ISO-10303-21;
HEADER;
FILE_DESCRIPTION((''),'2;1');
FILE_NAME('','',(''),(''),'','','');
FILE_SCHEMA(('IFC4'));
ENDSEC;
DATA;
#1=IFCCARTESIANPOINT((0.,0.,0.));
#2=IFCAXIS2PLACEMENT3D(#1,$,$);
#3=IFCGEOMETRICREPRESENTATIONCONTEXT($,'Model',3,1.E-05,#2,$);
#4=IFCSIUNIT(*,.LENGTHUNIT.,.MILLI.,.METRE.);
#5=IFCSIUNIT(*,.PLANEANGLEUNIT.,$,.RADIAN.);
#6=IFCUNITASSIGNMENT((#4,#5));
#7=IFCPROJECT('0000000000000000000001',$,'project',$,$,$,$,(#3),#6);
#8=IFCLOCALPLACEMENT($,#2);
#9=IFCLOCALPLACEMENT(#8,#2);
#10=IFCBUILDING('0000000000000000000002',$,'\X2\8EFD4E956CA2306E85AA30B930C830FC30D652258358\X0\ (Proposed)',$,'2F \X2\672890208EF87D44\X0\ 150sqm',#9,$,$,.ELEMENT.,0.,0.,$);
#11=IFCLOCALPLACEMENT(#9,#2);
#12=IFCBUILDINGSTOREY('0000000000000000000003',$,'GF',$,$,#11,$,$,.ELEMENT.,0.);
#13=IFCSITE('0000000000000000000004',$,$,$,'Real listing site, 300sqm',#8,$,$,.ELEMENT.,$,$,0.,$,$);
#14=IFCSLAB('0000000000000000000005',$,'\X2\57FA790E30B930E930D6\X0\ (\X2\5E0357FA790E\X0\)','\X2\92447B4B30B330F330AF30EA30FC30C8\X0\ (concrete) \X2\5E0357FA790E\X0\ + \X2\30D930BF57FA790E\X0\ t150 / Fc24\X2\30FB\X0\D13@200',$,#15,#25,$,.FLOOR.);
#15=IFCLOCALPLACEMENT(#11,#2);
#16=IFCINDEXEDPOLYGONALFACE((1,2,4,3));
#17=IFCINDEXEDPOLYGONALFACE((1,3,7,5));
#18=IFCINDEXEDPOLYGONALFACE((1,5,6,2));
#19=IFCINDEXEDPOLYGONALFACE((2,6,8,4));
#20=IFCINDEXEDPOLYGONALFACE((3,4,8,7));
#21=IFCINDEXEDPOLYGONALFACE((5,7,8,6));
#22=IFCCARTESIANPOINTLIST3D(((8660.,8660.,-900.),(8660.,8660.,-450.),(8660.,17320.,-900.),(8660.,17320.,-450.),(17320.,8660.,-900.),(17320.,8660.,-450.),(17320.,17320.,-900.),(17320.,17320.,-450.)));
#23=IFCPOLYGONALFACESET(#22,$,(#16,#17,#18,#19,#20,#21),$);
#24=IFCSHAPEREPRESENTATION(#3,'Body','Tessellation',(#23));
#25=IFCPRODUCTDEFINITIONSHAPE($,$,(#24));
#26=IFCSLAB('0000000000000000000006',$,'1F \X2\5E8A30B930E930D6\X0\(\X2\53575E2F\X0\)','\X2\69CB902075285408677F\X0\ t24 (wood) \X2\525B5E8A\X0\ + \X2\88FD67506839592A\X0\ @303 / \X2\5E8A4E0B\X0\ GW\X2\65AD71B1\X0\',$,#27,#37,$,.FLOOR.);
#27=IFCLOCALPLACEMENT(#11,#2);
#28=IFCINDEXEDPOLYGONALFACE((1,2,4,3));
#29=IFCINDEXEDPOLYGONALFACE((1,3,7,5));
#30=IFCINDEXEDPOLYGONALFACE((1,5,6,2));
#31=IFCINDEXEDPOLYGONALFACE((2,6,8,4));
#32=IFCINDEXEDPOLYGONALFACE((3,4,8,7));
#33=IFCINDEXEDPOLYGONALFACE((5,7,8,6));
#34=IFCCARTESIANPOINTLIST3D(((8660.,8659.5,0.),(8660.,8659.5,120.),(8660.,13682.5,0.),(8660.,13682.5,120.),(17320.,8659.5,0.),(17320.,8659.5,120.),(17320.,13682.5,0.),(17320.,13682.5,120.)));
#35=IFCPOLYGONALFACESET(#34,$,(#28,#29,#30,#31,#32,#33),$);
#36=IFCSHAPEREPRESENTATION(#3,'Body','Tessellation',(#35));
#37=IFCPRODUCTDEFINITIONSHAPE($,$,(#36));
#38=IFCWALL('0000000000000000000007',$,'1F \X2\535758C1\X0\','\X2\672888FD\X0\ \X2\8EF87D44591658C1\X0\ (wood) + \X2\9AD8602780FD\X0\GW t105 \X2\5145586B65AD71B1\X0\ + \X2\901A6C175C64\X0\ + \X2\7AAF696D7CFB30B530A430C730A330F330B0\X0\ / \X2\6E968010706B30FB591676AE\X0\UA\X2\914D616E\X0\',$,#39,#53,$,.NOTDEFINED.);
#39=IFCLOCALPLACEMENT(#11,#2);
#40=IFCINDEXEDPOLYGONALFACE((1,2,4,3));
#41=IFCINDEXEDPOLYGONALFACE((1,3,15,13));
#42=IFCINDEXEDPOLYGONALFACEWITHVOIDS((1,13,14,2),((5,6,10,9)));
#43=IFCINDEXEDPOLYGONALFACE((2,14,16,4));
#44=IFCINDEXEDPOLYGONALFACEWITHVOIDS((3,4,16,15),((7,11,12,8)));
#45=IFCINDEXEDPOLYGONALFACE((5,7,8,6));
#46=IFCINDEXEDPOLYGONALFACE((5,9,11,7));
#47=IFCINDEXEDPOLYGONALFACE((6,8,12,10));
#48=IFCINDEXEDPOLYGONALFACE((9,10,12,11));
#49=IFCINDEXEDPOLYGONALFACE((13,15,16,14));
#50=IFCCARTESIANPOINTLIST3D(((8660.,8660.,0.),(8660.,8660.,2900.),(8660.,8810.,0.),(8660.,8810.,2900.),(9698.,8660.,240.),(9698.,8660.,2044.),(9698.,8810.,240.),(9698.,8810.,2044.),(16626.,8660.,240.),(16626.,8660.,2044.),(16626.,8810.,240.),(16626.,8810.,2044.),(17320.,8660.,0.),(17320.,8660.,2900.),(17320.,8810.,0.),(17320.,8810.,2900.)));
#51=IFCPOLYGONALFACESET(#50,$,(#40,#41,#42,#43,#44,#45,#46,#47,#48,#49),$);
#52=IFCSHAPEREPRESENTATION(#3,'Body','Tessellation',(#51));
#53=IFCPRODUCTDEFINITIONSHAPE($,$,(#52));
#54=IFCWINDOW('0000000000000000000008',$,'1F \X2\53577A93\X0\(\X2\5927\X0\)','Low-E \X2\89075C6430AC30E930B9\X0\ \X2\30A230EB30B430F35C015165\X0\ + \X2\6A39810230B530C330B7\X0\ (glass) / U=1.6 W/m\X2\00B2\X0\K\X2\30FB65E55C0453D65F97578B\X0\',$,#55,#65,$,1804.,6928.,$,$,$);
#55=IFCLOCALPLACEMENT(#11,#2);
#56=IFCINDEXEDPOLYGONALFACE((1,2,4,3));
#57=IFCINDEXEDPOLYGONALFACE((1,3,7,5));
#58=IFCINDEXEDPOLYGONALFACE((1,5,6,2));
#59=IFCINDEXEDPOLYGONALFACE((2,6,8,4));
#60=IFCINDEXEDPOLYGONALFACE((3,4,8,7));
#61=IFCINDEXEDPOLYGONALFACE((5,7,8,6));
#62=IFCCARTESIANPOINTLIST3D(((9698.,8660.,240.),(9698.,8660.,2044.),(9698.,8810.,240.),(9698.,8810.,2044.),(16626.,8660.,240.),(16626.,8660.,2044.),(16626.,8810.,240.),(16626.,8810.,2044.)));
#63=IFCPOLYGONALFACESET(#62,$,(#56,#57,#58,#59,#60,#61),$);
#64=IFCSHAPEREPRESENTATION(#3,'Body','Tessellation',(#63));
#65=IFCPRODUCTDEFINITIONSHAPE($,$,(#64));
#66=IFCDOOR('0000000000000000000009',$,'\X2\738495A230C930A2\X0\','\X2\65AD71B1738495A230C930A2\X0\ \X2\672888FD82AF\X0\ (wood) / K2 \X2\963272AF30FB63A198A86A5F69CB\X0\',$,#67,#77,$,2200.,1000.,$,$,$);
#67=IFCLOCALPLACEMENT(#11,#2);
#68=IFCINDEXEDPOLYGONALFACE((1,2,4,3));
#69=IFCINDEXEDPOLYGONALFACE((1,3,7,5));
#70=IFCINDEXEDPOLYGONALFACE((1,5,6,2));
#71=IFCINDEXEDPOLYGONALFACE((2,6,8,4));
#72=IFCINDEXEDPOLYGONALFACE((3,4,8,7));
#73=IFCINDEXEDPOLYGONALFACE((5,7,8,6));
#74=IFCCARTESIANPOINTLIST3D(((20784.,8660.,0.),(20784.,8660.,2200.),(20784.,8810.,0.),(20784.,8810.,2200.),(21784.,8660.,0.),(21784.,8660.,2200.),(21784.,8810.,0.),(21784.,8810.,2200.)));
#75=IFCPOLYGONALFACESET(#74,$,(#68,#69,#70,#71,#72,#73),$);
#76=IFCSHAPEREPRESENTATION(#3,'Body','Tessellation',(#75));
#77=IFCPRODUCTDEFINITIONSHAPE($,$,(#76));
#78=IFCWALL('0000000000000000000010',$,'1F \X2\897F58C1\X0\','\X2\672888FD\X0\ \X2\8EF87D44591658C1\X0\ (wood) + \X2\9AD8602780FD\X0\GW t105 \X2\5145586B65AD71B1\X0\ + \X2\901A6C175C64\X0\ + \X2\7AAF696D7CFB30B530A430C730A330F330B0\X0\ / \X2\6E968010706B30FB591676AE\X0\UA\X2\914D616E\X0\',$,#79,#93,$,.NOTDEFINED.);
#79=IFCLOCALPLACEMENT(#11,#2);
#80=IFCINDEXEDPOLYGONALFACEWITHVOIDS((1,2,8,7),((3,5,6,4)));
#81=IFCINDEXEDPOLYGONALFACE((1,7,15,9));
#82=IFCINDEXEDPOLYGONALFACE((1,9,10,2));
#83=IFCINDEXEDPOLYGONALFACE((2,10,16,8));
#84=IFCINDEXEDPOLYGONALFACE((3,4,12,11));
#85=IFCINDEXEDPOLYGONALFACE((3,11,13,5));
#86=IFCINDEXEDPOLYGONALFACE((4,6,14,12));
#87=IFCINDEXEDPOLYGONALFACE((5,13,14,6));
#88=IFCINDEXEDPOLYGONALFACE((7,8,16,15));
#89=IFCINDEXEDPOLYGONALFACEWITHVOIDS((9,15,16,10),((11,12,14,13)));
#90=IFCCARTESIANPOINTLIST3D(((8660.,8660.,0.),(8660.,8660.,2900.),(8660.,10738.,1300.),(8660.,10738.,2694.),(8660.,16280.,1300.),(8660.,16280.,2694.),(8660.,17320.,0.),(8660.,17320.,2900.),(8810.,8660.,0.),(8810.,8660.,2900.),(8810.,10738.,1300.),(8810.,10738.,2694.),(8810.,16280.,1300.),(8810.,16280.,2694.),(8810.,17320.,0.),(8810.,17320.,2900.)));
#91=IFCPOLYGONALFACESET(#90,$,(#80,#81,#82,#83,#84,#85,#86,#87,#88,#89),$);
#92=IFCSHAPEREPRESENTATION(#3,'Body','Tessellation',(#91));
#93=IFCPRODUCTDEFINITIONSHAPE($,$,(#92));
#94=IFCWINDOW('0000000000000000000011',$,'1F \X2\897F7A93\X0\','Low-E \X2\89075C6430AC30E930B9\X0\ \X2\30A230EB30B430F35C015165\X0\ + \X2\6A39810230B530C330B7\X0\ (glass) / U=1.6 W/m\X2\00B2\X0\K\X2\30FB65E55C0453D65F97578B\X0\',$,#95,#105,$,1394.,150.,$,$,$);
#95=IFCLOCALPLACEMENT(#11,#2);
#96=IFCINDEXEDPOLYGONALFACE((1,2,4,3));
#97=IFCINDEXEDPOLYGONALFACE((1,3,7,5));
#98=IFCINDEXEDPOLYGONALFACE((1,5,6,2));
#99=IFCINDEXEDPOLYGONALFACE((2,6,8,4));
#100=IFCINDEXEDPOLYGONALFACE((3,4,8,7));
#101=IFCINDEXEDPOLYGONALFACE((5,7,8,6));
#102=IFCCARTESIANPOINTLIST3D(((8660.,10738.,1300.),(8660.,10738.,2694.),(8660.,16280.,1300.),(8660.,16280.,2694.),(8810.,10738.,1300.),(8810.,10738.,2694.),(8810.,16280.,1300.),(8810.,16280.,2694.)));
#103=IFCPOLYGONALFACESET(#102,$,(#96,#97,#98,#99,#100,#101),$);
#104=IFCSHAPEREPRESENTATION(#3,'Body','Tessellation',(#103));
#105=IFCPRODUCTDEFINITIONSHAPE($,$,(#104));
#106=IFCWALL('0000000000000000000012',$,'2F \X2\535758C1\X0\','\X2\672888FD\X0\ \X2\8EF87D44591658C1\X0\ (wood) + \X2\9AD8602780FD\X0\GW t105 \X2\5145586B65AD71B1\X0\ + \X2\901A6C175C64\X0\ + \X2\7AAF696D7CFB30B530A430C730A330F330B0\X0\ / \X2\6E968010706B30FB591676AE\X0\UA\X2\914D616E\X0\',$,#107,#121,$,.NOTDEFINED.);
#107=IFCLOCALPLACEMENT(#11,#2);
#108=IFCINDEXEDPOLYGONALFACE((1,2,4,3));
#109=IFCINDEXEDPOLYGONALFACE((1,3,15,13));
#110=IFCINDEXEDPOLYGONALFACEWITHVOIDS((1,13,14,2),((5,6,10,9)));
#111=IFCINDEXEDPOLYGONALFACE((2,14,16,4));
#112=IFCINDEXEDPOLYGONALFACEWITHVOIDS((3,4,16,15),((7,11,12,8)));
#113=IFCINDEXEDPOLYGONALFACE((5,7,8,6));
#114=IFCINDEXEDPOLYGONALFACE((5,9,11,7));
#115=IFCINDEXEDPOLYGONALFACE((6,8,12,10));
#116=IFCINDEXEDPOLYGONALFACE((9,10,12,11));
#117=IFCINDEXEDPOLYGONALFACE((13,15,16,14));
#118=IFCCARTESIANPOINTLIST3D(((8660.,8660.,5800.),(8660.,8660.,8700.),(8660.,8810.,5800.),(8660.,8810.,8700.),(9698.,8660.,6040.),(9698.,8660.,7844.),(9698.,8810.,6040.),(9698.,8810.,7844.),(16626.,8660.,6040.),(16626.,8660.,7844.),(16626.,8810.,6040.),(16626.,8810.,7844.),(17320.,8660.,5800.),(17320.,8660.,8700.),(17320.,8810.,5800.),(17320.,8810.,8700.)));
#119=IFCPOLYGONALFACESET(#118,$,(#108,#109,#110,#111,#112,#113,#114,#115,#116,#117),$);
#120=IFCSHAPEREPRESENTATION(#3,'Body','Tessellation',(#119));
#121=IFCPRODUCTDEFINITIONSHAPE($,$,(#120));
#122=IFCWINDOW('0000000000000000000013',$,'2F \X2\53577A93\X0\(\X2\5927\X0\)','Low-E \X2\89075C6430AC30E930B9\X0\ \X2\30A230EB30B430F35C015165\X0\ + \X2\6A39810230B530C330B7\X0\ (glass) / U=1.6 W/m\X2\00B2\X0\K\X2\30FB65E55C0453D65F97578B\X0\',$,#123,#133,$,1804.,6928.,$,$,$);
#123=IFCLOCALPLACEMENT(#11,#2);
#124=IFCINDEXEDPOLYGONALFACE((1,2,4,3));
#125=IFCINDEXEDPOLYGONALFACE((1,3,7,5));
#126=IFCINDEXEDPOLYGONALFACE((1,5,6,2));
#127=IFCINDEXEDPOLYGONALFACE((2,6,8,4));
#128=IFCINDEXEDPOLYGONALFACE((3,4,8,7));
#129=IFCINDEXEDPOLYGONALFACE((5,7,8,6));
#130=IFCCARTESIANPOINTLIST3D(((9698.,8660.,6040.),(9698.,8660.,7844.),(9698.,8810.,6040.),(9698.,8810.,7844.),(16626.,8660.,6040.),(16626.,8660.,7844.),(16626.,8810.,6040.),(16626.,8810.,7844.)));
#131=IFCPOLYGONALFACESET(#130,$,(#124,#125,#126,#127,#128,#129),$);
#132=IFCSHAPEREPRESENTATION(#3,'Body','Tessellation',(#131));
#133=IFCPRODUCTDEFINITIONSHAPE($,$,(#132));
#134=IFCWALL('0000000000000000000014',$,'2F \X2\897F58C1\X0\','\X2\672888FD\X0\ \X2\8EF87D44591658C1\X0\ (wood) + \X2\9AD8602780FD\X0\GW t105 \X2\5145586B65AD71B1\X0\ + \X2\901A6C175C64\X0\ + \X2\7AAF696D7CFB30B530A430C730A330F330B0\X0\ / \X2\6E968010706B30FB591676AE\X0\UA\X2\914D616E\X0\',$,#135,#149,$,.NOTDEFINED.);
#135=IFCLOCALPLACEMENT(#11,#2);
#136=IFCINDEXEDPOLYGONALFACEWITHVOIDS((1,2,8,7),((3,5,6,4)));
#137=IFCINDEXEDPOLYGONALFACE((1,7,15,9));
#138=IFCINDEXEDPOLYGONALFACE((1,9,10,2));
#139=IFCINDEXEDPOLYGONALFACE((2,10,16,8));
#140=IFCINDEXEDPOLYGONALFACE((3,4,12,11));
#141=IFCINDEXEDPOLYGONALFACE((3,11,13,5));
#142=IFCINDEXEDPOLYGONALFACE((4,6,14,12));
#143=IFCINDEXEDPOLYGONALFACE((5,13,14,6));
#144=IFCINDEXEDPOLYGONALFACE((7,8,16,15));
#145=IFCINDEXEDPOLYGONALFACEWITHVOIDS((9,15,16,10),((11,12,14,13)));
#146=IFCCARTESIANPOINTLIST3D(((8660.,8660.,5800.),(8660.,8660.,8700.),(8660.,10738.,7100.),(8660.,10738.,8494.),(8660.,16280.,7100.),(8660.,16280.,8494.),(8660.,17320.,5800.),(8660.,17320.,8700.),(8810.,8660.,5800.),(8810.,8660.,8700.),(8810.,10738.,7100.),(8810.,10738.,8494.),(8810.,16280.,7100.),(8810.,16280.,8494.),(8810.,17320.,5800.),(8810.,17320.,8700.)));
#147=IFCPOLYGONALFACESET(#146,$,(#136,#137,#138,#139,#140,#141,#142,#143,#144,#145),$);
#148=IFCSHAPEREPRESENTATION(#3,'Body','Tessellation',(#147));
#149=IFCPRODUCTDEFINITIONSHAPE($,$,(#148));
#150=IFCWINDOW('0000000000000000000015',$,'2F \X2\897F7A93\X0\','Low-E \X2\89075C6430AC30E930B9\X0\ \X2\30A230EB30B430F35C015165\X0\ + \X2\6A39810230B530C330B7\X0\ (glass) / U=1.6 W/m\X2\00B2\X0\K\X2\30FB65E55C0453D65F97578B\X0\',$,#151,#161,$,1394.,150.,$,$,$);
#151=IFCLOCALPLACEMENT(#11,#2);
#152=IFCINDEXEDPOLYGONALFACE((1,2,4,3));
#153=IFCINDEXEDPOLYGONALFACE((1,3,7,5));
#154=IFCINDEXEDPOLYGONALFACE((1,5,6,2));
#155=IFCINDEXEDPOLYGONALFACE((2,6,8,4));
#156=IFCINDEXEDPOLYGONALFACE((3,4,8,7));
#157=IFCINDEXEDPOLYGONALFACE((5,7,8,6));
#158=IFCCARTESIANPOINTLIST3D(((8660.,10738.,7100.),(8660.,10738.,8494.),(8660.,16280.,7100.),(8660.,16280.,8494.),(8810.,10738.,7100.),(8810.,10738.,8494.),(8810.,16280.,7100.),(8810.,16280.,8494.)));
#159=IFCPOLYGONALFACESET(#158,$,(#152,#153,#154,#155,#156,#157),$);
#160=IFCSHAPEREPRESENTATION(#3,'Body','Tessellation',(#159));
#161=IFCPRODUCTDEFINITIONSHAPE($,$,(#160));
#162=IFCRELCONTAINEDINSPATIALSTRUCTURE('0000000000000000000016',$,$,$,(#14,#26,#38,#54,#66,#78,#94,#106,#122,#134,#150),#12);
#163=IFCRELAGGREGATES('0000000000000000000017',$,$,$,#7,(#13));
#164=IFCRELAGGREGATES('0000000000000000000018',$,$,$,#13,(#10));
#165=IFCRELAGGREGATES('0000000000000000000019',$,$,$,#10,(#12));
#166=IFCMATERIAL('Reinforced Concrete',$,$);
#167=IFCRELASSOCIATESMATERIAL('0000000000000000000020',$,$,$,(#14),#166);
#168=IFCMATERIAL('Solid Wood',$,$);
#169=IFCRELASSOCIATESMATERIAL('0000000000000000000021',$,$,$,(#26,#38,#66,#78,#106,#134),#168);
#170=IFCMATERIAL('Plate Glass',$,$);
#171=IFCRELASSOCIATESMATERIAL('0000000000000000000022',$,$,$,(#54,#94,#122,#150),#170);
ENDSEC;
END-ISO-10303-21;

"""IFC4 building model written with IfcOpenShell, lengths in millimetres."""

from ifc_helpers import new_model, si_unit, frame, frame_2d, origin, place, context, project, spatial, rectangle, extrude, material, element, fill, save


model = new_model("IFC4")

# Units and contexts
model_context = context("Model", 3, precision=1e-05, world=origin())
ifc_project = project(units=[si_unit("LENGTHUNIT", "METRE", prefix="MILLI"), si_unit("PLANEANGLEUNIT", "RADIAN")], contexts=[model_context])

# Site, building, storey
site_placement = place(None, origin())
site = spatial("IfcSite", under=ifc_project, at=site_placement, ObjectType="Real listing site, 300sqm", CompositionType="ELEMENT", RefElevation=0.0)
building_placement = place(site_placement, origin())
building = spatial("IfcBuilding", under=site, at=building_placement, Name="軽井沢の薪ストーブ別荘 (Proposed)", ObjectType="2F 木造軸組 150sqm", CompositionType="ELEMENT", ElevationOfRefHeight=0.0, ElevationOfTerrain=0.0)
storey_placement = place(building_placement, origin())
storey = spatial("IfcBuildingStorey", under=building, at=storey_placement, Name="GF", CompositionType="ELEMENT", Elevation=0.0)

# Slabs
ifc_material_1 = material(Name="Reinforced Concrete")
slab_1_placement = place(storey_placement, frame((4330.0, 4330.0, -450.0)))
element("IfcSlab", 1, at=slab_1_placement, inside=storey, material=ifc_material_1, Name="基礎スラブ (布基礎)", Description="鉄筋コンクリート (concrete) 布基礎 + ベタ基礎 t150 / Fc24・D13@200", PredefinedType="FLOOR", context=model_context, shape_type="SweptSolid", body=[
    extrude(rectangle(XDim=8660.0, YDim=8660.0, at=frame_2d((4330.0, 4330.0))), frame((4330.0, 4330.0, -450.0)), (0.0, 0.0, 1.0), 450.0),
])
ifc_material_2 = material(Name="Solid Wood")
slab_2_placement = place(storey_placement, frame((4330.0, 4330.0, 0.0)))
element("IfcSlab", 2, at=slab_2_placement, inside=storey, material=ifc_material_2, Name="1F 床スラブ(南帯)", Description="構造用合板 t24 (wood) 剛床 + 製材根太 @303 / 床下 GW断熱", PredefinedType="FLOOR", context=model_context, shape_type="SweptSolid", body=[
    extrude(rectangle(XDim=8660.0, YDim=5023.0, at=frame_2d((4330.0, 2511.0))), frame((4330.0, 4330.0, 0.0)), (0.0, 0.0, 1.0), 120.0),
])

# Wall, openings, window, door
wall_1_placement = place(storey_placement, frame((4330.0, 4330.0, 0.0)))
wall_1 = element("IfcWall", 3, at=wall_1_placement, inside=storey, material=ifc_material_2, Name="1F 南壁", Description="木製 軸組外壁 (wood) + 高性能GW t105 充填断熱 + 通気層 + 窯業系サイディング / 準耐火・外皮UA配慮", PredefinedType="NOTDEFINED", context=model_context, shape_type="SweptSolid", body=[
    extrude(rectangle(XDim=8660.0, YDim=150.0, at=frame_2d((4330.0, 75.0))), frame((4330.0, 4330.0, 0.0)), (0.0, 0.0, 1.0), 2900.0),
])
opening_1_placement = place(storey_placement, frame((4849.0, 4330.0, 120.0)))
opening_1 = element("IfcOpeningElement", 4, at=opening_1_placement, cuts=wall_1, PredefinedType="NOTDEFINED", context=model_context, shape_type="SweptSolid", body=[
    extrude(rectangle(XDim=6928.0, YDim=150.0, at=frame_2d((3464.0, 75.0))), frame((4849.0, 4330.0, 120.0)), (0.0, 0.0, 1.0), 1804.0),
])
opening_2_placement = place(storey_placement, frame((10392.0, 4330.0, 0.0)))
opening_2 = element("IfcOpeningElement", 5, at=opening_2_placement, cuts=wall_1, PredefinedType="NOTDEFINED", context=model_context, shape_type="SweptSolid", body=[
    extrude(rectangle(XDim=1000.0, YDim=150.0, at=frame_2d((500.0, 75.0))), frame((10392.0, 4330.0, 0.0)), (0.0, 0.0, 1.0), 2200.0),
])
ifc_material_3 = material(Name="Plate Glass")
window_1_placement = place(storey_placement, frame((4849.0, 4330.0, 120.0)))
window_1 = element("IfcWindow", 6, at=window_1_placement, inside=storey, material=ifc_material_3, Name="1F 南窓(大)", Description="Low-E 複層ガラス アルゴン封入 + 樹脂サッシ (glass) / U=1.6 W/m²K・日射取得型", OverallHeight=1804.0, OverallWidth=6928.0, context=model_context, shape_type="SweptSolid", body=[
    extrude(rectangle(XDim=6928.0, YDim=150.0, at=frame_2d((3464.0, 75.0))), frame((4849.0, 4330.0, 120.0)), (0.0, 0.0, 1.0), 1804.0),
])
fill(opening_1, window_1)
door_placement = place(storey_placement, frame((10392.0, 4330.0, 0.0)))
door = element("IfcDoor", 7, at=door_placement, inside=storey, material=ifc_material_2, Name="玄関ドア", Description="断熱玄関ドア 木製芯 (wood) / K2 防犯・採風機構", OverallHeight=2200.0, OverallWidth=1000.0, context=model_context, shape_type="SweptSolid", body=[
    extrude(rectangle(XDim=1000.0, YDim=150.0, at=frame_2d((500.0, 75.0))), frame((10392.0, 4330.0, 0.0)), (0.0, 0.0, 1.0), 2200.0),
])
fill(opening_2, door)

# Wall, opening, window
wall_2_placement = place(storey_placement, frame((4330.0, 4330.0, 0.0)))
wall_2 = element("IfcWall", 8, at=wall_2_placement, inside=storey, material=ifc_material_2, Name="1F 西壁", Description="木製 軸組外壁 (wood) + 高性能GW t105 充填断熱 + 通気層 + 窯業系サイディング / 準耐火・外皮UA配慮", PredefinedType="NOTDEFINED", context=model_context, shape_type="SweptSolid", body=[
    extrude(rectangle(XDim=150.0, YDim=8660.0, at=frame_2d((75.0, 4330.0))), frame((4330.0, 4330.0, 0.0)), (0.0, 0.0, 1.0), 2900.0),
])
opening_3_placement = place(storey_placement, frame((4330.0, 5369.0, 650.0)))
opening_3 = element("IfcOpeningElement", 9, at=opening_3_placement, cuts=wall_2, PredefinedType="NOTDEFINED", context=model_context, shape_type="SweptSolid", body=[
    extrude(rectangle(XDim=150.0, YDim=5542.0, at=frame_2d((75.0, 2771.0))), frame((4330.0, 5369.0, 650.0)), (0.0, 0.0, 1.0), 1394.0),
])
window_2_placement = place(storey_placement, frame((4330.0, 5369.0, 650.0)))
window_2 = element("IfcWindow", 10, at=window_2_placement, inside=storey, material=ifc_material_3, Name="1F 西窓", Description="Low-E 複層ガラス アルゴン封入 + 樹脂サッシ (glass) / U=1.6 W/m²K・日射取得型", OverallHeight=1394.0, OverallWidth=150.0, context=model_context, shape_type="SweptSolid", body=[
    extrude(rectangle(XDim=150.0, YDim=5542.0, at=frame_2d((75.0, 2771.0))), frame((4330.0, 5369.0, 650.0)), (0.0, 0.0, 1.0), 1394.0),
])
fill(opening_3, window_2)

# Walls, openings, windows
wall_3_placement = place(storey_placement, frame((4330.0, 4330.0, 2900.0)))
wall_3 = element("IfcWall", 11, at=wall_3_placement, inside=storey, material=ifc_material_2, Name="2F 南壁", Description="木製 軸組外壁 (wood) + 高性能GW t105 充填断熱 + 通気層 + 窯業系サイディング / 準耐火・外皮UA配慮", PredefinedType="NOTDEFINED", context=model_context, shape_type="SweptSolid", body=[
    extrude(rectangle(XDim=8660.0, YDim=150.0, at=frame_2d((4330.0, 75.0))), frame((4330.0, 4330.0, 2900.0)), (0.0, 0.0, 1.0), 2900.0),
])
opening_4_placement = place(storey_placement, frame((4849.0, 4330.0, 3020.0)))
opening_4 = element("IfcOpeningElement", 12, at=opening_4_placement, cuts=wall_3, PredefinedType="NOTDEFINED", context=model_context, shape_type="SweptSolid", body=[
    extrude(rectangle(XDim=6928.0, YDim=150.0, at=frame_2d((3464.0, 75.0))), frame((4849.0, 4330.0, 3020.0)), (0.0, 0.0, 1.0), 1804.0),
])
window_3_placement = place(storey_placement, frame((4849.0, 4330.0, 3020.0)))
window_3 = element("IfcWindow", 13, at=window_3_placement, inside=storey, material=ifc_material_3, Name="2F 南窓(大)", Description="Low-E 複層ガラス アルゴン封入 + 樹脂サッシ (glass) / U=1.6 W/m²K・日射取得型", OverallHeight=1804.0, OverallWidth=6928.0, context=model_context, shape_type="SweptSolid", body=[
    extrude(rectangle(XDim=6928.0, YDim=150.0, at=frame_2d((3464.0, 75.0))), frame((4849.0, 4330.0, 3020.0)), (0.0, 0.0, 1.0), 1804.0),
])
fill(opening_4, window_3)
wall_4_placement = place(storey_placement, frame((4330.0, 4330.0, 2900.0)))
wall_4 = element("IfcWall", 14, at=wall_4_placement, inside=storey, material=ifc_material_2, Name="2F 西壁", Description="木製 軸組外壁 (wood) + 高性能GW t105 充填断熱 + 通気層 + 窯業系サイディング / 準耐火・外皮UA配慮", PredefinedType="NOTDEFINED", context=model_context, shape_type="SweptSolid", body=[
    extrude(rectangle(XDim=150.0, YDim=8660.0, at=frame_2d((75.0, 4330.0))), frame((4330.0, 4330.0, 2900.0)), (0.0, 0.0, 1.0), 2900.0),
])
opening_5_placement = place(storey_placement, frame((4330.0, 5369.0, 3550.0)))
opening_5 = element("IfcOpeningElement", 15, at=opening_5_placement, cuts=wall_4, PredefinedType="NOTDEFINED", context=model_context, shape_type="SweptSolid", body=[
    extrude(rectangle(XDim=150.0, YDim=5542.0, at=frame_2d((75.0, 2771.0))), frame((4330.0, 5369.0, 3550.0)), (0.0, 0.0, 1.0), 1394.0),
])
window_4_placement = place(storey_placement, frame((4330.0, 5369.0, 3550.0)))
window_4 = element("IfcWindow", 16, at=window_4_placement, inside=storey, material=ifc_material_3, Name="2F 西窓", Description="Low-E 複層ガラス アルゴン封入 + 樹脂サッシ (glass) / U=1.6 W/m²K・日射取得型", OverallHeight=1394.0, OverallWidth=150.0, context=model_context, shape_type="SweptSolid", body=[
    extrude(rectangle(XDim=150.0, YDim=5542.0, at=frame_2d((75.0, 2771.0))), frame((4330.0, 5369.0, 3550.0)), (0.0, 0.0, 1.0), 1394.0),
])
fill(opening_5, window_4)

save(model, "model.ifc")
